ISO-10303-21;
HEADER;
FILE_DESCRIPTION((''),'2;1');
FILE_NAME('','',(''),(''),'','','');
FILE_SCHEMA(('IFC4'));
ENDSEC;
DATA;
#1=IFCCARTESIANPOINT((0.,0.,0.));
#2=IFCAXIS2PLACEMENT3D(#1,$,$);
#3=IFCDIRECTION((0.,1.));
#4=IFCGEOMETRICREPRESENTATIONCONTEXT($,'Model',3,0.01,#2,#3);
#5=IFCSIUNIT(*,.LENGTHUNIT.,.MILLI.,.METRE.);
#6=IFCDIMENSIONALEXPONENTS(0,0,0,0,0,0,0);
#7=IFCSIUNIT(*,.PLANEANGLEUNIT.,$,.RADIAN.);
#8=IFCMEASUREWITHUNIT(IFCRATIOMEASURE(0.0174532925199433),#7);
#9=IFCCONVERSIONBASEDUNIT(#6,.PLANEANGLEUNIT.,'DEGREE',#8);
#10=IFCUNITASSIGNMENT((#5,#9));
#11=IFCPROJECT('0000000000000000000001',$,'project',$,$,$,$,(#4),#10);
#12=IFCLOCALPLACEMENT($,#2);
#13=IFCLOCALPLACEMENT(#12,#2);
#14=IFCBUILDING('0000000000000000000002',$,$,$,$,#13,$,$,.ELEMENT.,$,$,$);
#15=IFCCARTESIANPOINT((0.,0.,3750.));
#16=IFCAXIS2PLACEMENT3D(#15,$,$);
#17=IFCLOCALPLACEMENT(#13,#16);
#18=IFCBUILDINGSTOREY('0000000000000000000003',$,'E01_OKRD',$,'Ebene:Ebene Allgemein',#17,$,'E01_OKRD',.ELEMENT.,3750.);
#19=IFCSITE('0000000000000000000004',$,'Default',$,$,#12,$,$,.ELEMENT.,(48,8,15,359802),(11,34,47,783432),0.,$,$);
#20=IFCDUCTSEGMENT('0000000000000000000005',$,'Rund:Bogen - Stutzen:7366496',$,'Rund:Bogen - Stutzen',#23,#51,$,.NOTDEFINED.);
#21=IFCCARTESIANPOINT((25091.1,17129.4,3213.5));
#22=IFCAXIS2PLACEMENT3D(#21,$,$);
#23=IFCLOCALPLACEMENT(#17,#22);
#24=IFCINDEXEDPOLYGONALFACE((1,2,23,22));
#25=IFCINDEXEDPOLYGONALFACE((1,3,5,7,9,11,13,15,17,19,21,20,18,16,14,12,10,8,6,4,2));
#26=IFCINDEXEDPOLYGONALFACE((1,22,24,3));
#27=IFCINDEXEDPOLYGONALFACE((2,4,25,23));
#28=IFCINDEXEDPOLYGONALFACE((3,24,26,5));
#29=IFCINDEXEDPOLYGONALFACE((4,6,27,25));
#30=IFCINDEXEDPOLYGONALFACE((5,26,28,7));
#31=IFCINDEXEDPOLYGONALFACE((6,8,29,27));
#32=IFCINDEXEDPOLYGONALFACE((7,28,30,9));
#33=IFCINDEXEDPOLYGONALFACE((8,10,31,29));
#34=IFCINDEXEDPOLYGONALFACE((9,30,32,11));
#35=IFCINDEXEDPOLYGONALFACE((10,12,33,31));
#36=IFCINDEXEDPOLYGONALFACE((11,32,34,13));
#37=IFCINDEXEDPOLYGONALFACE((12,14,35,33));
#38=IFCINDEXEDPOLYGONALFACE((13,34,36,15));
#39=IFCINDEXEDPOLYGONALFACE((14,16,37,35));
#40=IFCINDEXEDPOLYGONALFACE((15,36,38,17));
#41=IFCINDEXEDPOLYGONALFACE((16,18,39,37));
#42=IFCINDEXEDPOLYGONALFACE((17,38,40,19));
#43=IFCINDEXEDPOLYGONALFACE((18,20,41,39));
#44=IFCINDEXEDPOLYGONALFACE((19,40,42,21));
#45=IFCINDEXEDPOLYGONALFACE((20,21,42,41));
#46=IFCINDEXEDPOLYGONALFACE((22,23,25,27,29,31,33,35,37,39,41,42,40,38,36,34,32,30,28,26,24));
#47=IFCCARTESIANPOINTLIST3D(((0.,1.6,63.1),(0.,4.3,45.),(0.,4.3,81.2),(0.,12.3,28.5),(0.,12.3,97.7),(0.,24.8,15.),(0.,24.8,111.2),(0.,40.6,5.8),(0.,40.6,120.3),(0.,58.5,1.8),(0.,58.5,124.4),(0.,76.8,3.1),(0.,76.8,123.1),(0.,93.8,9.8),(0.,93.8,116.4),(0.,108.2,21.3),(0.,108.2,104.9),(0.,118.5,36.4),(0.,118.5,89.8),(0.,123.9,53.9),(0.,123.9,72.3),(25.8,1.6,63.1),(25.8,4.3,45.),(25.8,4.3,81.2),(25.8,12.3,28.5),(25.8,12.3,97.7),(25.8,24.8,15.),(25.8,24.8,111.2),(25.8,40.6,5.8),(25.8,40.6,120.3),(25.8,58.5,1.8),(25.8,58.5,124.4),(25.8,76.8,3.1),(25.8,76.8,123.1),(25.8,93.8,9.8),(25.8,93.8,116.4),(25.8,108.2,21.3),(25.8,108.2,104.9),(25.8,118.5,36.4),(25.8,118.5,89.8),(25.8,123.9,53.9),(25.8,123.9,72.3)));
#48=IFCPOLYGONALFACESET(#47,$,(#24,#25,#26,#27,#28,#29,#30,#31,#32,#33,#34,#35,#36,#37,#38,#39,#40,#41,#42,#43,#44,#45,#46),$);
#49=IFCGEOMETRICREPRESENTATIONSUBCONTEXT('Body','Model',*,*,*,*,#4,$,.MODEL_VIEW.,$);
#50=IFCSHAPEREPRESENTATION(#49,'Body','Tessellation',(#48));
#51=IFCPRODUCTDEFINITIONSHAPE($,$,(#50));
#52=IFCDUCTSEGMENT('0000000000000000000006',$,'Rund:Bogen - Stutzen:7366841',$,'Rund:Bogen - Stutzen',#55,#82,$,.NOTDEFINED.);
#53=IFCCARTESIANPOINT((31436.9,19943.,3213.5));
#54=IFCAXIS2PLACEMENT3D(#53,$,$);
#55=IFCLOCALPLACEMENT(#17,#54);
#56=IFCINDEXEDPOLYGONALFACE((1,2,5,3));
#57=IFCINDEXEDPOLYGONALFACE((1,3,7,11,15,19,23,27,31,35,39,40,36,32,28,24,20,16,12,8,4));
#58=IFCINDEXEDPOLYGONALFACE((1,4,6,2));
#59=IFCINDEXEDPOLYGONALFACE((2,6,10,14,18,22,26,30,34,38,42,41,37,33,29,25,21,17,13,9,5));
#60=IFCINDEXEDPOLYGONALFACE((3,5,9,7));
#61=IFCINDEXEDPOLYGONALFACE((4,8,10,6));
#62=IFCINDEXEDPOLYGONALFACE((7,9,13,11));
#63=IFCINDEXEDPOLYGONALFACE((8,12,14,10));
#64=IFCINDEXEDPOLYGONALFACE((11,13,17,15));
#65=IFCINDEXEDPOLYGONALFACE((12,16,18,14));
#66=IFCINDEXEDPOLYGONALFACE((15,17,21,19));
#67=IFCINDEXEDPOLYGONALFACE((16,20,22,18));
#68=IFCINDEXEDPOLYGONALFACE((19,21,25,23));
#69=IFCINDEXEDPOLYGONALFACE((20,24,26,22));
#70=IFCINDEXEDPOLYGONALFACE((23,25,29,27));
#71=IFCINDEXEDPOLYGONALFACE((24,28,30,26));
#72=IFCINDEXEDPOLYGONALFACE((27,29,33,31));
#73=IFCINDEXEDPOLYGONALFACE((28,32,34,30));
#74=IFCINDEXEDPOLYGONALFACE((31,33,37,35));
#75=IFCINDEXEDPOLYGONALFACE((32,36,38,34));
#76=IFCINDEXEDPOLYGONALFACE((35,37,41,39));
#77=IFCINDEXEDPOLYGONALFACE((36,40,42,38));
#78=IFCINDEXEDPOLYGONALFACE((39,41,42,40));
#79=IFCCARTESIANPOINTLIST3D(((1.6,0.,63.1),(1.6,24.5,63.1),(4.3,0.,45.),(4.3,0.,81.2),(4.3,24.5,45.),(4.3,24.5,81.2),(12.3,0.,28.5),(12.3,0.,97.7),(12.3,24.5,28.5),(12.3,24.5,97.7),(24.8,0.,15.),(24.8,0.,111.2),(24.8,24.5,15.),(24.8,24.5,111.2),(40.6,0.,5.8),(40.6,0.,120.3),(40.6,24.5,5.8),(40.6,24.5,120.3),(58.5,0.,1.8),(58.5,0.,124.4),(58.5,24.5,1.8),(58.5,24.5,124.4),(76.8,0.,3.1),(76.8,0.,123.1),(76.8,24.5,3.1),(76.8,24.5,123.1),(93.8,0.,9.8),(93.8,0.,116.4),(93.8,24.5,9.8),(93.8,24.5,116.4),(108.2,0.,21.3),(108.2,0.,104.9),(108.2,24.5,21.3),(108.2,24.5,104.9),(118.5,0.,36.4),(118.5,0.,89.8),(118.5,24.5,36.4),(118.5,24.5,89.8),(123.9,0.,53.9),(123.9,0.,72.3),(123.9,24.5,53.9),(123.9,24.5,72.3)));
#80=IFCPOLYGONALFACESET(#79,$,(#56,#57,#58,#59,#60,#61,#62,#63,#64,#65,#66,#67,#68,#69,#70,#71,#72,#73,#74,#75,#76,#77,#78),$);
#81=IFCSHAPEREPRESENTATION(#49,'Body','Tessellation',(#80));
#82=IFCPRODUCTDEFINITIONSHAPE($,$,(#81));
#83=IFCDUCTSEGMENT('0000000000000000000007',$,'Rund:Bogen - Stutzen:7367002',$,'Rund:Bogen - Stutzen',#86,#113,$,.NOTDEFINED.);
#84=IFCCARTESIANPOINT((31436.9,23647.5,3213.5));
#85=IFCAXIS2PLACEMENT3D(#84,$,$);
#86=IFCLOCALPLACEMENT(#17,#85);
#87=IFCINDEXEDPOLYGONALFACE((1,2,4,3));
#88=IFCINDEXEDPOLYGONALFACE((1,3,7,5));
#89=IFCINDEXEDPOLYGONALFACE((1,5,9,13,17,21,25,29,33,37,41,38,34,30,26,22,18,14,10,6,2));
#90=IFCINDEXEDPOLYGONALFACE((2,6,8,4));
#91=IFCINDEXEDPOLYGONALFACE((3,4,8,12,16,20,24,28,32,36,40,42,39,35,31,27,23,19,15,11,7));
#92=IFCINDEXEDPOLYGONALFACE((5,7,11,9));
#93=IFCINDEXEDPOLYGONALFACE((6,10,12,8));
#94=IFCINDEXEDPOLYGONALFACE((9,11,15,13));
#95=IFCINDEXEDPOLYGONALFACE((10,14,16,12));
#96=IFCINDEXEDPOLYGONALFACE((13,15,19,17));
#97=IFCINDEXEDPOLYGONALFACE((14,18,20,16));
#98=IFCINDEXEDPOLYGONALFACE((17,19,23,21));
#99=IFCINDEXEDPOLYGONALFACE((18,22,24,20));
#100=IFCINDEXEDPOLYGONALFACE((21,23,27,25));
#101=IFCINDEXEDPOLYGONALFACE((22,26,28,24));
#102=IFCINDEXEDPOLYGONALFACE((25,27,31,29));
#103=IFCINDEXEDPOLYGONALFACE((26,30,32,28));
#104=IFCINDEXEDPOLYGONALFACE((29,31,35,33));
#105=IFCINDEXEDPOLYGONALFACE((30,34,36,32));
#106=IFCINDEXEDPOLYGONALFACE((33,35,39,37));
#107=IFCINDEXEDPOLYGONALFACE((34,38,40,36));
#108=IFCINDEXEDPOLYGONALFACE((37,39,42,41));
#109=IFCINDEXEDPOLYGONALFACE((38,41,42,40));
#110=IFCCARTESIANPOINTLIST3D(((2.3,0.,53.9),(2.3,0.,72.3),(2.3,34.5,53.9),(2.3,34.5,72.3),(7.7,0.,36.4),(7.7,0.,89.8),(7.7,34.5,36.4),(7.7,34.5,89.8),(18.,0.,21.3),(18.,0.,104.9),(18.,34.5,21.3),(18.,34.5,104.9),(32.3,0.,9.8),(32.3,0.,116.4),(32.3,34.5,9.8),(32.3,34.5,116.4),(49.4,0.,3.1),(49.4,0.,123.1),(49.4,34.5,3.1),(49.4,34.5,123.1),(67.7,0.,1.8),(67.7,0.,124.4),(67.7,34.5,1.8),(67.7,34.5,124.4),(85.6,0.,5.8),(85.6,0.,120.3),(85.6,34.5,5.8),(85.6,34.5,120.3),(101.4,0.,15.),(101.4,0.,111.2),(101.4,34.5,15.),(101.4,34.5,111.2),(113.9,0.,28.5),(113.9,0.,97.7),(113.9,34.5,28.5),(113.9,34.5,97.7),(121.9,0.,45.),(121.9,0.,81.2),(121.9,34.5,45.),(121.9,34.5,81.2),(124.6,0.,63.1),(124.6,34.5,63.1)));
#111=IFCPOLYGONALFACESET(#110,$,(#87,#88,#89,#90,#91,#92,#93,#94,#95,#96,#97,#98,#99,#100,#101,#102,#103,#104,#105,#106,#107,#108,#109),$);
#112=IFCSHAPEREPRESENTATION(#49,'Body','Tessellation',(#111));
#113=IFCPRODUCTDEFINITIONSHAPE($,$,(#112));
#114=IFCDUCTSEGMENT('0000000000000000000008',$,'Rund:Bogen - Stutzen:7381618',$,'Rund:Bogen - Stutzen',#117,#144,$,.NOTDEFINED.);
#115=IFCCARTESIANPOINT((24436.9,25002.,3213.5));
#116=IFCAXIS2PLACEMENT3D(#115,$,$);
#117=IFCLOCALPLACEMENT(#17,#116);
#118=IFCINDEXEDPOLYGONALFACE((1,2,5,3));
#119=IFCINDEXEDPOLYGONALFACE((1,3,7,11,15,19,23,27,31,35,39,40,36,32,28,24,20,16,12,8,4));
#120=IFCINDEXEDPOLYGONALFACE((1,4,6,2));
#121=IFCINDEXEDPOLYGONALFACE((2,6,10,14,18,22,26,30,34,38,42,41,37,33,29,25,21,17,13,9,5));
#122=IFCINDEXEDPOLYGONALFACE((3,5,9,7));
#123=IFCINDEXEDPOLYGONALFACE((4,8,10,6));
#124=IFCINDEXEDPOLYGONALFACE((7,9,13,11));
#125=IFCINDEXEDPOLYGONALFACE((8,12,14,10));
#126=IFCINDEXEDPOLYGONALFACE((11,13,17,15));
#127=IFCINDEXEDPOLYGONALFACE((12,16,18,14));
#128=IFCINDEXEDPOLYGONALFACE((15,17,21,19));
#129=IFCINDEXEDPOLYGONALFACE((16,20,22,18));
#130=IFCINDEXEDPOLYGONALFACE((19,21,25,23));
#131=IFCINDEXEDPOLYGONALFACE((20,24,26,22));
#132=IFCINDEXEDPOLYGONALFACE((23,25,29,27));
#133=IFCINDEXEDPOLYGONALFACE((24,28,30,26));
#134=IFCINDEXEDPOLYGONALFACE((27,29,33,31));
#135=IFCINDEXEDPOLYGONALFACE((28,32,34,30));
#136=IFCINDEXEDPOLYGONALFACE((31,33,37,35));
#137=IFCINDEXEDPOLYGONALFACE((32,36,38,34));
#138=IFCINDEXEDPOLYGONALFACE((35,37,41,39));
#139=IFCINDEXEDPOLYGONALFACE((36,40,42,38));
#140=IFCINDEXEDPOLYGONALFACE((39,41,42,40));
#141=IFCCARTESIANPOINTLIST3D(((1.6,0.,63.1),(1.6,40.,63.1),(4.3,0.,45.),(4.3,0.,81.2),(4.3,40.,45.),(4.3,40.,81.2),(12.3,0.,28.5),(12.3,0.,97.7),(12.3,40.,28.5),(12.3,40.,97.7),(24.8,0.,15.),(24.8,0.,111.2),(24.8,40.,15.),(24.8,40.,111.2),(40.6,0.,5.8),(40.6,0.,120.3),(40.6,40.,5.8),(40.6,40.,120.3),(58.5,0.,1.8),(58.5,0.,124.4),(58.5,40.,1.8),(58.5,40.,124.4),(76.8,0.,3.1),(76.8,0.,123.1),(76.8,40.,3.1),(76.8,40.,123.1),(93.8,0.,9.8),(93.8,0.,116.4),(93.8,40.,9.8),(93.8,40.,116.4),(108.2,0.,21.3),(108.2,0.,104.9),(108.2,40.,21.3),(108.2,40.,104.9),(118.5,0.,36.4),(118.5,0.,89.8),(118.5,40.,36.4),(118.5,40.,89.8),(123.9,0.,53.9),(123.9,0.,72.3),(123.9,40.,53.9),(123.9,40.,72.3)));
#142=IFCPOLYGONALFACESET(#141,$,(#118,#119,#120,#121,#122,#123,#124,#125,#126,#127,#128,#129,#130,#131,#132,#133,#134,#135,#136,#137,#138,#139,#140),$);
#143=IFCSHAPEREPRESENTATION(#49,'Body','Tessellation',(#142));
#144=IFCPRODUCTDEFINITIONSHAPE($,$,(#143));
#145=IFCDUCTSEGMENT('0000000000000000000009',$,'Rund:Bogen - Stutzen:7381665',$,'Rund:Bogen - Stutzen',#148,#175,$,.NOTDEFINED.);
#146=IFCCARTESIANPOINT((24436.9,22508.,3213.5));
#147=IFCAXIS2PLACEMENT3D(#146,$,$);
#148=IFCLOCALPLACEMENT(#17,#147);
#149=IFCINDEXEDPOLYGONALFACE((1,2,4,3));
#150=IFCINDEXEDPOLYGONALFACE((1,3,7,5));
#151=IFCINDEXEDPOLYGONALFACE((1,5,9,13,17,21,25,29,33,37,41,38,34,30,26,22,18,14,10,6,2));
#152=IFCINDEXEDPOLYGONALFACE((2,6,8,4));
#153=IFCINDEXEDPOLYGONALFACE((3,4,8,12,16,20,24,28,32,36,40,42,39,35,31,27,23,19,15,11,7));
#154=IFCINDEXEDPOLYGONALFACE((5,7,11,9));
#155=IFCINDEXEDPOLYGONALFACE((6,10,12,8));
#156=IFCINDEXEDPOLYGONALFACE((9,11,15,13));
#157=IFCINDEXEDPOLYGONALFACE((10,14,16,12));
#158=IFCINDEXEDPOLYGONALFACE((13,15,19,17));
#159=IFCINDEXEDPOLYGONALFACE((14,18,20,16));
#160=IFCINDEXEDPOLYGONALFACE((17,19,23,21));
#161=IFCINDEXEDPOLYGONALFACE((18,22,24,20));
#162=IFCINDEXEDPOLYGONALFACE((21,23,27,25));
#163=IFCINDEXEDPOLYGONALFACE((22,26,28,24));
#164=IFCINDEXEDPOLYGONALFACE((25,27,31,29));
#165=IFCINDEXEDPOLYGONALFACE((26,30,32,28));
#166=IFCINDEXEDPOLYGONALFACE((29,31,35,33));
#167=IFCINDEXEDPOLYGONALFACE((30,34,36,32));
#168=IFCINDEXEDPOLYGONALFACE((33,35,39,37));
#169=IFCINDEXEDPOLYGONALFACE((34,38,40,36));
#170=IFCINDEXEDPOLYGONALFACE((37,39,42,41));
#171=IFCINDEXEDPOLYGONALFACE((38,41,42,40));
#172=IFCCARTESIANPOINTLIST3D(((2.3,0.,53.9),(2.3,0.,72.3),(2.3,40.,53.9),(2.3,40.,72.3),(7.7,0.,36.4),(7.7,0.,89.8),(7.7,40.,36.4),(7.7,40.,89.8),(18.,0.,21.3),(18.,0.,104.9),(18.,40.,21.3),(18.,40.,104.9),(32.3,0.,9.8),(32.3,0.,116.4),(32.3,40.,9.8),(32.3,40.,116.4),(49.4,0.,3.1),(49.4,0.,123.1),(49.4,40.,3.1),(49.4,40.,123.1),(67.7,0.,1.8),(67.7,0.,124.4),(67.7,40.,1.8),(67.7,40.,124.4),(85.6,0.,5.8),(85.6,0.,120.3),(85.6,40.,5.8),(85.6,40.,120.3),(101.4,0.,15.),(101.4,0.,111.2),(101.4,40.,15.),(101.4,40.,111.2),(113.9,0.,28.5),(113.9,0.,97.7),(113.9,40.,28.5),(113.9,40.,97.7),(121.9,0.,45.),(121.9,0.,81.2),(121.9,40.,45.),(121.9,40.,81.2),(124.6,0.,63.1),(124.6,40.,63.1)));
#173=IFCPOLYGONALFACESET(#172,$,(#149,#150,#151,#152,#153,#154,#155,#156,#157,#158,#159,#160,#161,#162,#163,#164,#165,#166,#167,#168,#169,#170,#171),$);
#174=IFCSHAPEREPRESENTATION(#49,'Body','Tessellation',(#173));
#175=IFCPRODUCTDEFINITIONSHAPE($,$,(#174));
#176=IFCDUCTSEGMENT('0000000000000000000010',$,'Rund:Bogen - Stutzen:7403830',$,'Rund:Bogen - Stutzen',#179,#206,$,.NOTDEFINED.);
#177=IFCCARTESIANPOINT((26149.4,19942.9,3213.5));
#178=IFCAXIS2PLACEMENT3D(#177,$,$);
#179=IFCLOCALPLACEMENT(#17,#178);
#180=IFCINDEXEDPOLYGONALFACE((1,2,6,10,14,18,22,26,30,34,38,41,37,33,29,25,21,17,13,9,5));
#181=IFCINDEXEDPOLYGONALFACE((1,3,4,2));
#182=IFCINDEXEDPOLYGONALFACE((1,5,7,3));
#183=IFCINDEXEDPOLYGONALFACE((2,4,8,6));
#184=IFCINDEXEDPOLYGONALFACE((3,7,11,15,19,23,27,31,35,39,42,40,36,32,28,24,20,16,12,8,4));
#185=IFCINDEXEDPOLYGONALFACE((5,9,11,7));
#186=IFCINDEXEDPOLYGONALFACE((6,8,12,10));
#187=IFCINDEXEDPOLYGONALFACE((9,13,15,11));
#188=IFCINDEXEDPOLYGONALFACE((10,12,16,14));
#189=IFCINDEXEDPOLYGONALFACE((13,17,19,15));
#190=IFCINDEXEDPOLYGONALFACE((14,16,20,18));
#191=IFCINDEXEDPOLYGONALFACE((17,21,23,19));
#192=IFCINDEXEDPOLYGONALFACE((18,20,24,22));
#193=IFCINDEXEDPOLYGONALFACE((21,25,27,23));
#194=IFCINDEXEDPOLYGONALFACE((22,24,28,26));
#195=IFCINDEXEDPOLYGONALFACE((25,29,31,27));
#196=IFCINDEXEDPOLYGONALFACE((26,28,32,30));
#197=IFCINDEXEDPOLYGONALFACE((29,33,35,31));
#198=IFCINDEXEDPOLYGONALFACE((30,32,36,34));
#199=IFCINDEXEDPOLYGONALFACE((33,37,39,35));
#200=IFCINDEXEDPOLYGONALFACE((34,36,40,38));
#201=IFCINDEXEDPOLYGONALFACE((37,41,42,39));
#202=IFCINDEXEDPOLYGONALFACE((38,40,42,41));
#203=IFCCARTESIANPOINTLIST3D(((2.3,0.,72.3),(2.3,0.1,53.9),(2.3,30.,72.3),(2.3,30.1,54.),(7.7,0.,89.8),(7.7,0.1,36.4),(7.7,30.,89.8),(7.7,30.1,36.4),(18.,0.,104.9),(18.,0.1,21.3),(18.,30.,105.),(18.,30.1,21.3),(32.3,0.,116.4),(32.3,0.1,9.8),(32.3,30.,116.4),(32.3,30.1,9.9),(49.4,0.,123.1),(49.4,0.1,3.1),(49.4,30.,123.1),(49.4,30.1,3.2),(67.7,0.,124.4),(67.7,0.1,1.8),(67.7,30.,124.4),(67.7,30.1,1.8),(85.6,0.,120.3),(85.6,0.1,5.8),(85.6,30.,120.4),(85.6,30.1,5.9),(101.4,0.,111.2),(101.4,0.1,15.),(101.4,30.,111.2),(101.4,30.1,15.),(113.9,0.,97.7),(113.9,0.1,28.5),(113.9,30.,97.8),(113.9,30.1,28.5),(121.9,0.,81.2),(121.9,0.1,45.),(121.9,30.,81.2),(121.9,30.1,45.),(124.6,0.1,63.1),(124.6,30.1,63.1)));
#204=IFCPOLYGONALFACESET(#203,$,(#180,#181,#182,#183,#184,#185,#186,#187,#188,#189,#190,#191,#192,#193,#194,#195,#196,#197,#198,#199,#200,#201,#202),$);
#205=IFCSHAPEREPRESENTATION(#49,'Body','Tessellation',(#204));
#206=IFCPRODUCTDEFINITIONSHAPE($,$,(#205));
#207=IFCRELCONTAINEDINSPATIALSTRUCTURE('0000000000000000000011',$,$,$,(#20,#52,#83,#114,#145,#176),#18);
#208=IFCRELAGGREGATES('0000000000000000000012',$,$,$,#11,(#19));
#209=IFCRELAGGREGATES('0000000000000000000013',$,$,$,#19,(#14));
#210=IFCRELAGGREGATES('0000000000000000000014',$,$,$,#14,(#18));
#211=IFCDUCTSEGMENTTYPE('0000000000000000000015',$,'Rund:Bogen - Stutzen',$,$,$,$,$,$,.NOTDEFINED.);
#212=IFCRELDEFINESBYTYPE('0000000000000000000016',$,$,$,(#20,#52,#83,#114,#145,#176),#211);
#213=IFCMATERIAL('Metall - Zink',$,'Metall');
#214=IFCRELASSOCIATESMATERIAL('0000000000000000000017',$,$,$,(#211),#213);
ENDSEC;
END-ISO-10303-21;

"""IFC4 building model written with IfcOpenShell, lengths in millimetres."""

from ifc_helpers import new_model, entity, si_unit, converted_unit, direction, frame, frame_2d, origin, origin_2d_with_axis, place, context, subcontext, project, spatial, circle, extrude, material, type_object, element, save


model = new_model("IFC4")

# Units and contexts
model_context = context("Model", 3, precision=0.01, world=origin(), true_north=direction((0.0, 1.0)))
body_context = subcontext(model_context, "Body", "Model", "MODEL_VIEW")
ifc_project = project(units=[si_unit("LENGTHUNIT", "METRE", prefix="MILLI"), converted_unit("PLANEANGLEUNIT", "DEGREE", entity("IfcRatioMeasure", 0.0174532925199433), si_unit("PLANEANGLEUNIT", "RADIAN"), dimensions=[0, 0, 0, 0, 0, 0, 0])], contexts=[model_context])

# Site, building, storey
site_placement = place(None, origin())
site = spatial("IfcSite", under=ifc_project, at=site_placement, Name="Default", CompositionType="ELEMENT", RefLatitude=(48, 8, 15, 359802), RefLongitude=(11, 34, 47, 783432), RefElevation=0.0)
building_placement = place(site_placement, origin())
building = spatial("IfcBuilding", under=site, at=building_placement, CompositionType="ELEMENT")
storey_placement = place(building_placement, frame((0.0, 0.0, 3750.0)))
storey = spatial("IfcBuildingStorey", under=building, at=storey_placement, Name="E01_OKRD", ObjectType="Ebene:Ebene Allgemein", LongName="E01_OKRD", CompositionType="ELEMENT", Elevation=3750.0)

# Shared definitions
ifc_material_1 = material(Name="Metall - Zink", Category="Metall")

# Duct segments
duct_segment_type_1 = type_object("IfcDuctSegmentType", Name="Rund:Bogen - Stutzen", PredefinedType="NOTDEFINED", material=ifc_material_1)
duct_segment_1_placement = place(storey_placement, frame((25091.1, 17129.4, 3213.5)))
element("IfcDuctSegment", 1, at=duct_segment_1_placement, inside=storey, type_object=duct_segment_type_1, Name="Rund:Bogen - Stutzen:7366496", ObjectType="Rund:Bogen - Stutzen", PredefinedType="NOTDEFINED", context=body_context, shape_type="SweptSolid", body=[
    extrude(circle(Radius=61.5, at=frame_2d((0.0, 0.0), x_axis=(1.0, 0.0))), frame((0.0, 63.1, 63.1), z_axis=(1.0, 0.0, 0.0), x_axis=(0.0, -1.0, 0.0)), (0.0, 0.0, 1.0), 25.8),
])
duct_segment_2_placement = place(storey_placement, frame((31436.9, 19943.0, 3213.5)))
element("IfcDuctSegment", 2, at=duct_segment_2_placement, inside=storey, type_object=duct_segment_type_1, Name="Rund:Bogen - Stutzen:7366841", ObjectType="Rund:Bogen - Stutzen", PredefinedType="NOTDEFINED", context=body_context, shape_type="SweptSolid", body=[
    extrude(circle(Radius=61.5, at=frame_2d((0.0, 0.0), x_axis=(1.0, 0.0))), frame((63.1, 0.0, 63.1), z_axis=(0.0, 1.0, 0.0), x_axis=(-1.0, 0.0, 0.0)), (0.0, 0.0, 1.0), 24.5),
])
duct_segment_3_placement = place(storey_placement, frame((31436.9, 23647.5, 3213.5)))
element("IfcDuctSegment", 3, at=duct_segment_3_placement, inside=storey, type_object=duct_segment_type_1, Name="Rund:Bogen - Stutzen:7367002", ObjectType="Rund:Bogen - Stutzen", PredefinedType="NOTDEFINED", context=body_context, shape_type="SweptSolid", body=[
    extrude(circle(Radius=61.5, at=frame_2d((0.0, 0.0), x_axis=(1.0, 0.0))), frame((63.1, 0.0, 63.1), z_axis=(0.0, 1.0, 0.0), x_axis=(1.0, 0.0, 0.0)), (0.0, 0.0, 1.0), 34.5),
])
duct_segment_4_placement = place(storey_placement, frame((24436.9, 25002.0, 3213.5)))
element("IfcDuctSegment", 4, at=duct_segment_4_placement, inside=storey, type_object=duct_segment_type_1, Name="Rund:Bogen - Stutzen:7381618", ObjectType="Rund:Bogen - Stutzen", PredefinedType="NOTDEFINED", context=body_context, shape_type="SweptSolid", body=[
    extrude(circle(Radius=61.5, at=origin_2d_with_axis()), frame((63.1, 0.0, 63.1), z_axis=(0.0, 1.0, 0.0), x_axis=(-1.0, 0.0, 0.0)), (0.0, 0.0, 1.0), 40.0),
])
duct_segment_5_placement = place(storey_placement, frame((24436.9, 22508.0, 3213.5)))
element("IfcDuctSegment", 5, at=duct_segment_5_placement, inside=storey, type_object=duct_segment_type_1, Name="Rund:Bogen - Stutzen:7381665", ObjectType="Rund:Bogen - Stutzen", PredefinedType="NOTDEFINED", context=body_context, shape_type="SweptSolid", body=[
    extrude(circle(Radius=61.5, at=frame_2d((0.0, 0.0), x_axis=(1.0, 0.0))), frame((63.1, 0.0, 63.1), z_axis=(0.0, 1.0, 0.0), x_axis=(1.0, 0.0, 0.0)), (0.0, 0.0, 1.0), 40.0),
])
duct_segment_6_placement = place(storey_placement, frame((26149.4, 19942.9, 3213.5)))
element("IfcDuctSegment", 6, at=duct_segment_6_placement, inside=storey, type_object=duct_segment_type_1, Name="Rund:Bogen - Stutzen:7403830", ObjectType="Rund:Bogen - Stutzen", PredefinedType="NOTDEFINED", context=body_context, shape_type="SweptSolid", body=[
    extrude(circle(Radius=61.5, at=frame_2d((0.0, 0.0), x_axis=(1.0, 0.0))), frame((63.1, 0.1, 63.1), z_axis=(0.0, 1.0, 0.000858), x_axis=(1.0, 0.0, 0.0)), (0.0, 0.0, 1.0), 30.0),
])

save(model, "model.ifc")
